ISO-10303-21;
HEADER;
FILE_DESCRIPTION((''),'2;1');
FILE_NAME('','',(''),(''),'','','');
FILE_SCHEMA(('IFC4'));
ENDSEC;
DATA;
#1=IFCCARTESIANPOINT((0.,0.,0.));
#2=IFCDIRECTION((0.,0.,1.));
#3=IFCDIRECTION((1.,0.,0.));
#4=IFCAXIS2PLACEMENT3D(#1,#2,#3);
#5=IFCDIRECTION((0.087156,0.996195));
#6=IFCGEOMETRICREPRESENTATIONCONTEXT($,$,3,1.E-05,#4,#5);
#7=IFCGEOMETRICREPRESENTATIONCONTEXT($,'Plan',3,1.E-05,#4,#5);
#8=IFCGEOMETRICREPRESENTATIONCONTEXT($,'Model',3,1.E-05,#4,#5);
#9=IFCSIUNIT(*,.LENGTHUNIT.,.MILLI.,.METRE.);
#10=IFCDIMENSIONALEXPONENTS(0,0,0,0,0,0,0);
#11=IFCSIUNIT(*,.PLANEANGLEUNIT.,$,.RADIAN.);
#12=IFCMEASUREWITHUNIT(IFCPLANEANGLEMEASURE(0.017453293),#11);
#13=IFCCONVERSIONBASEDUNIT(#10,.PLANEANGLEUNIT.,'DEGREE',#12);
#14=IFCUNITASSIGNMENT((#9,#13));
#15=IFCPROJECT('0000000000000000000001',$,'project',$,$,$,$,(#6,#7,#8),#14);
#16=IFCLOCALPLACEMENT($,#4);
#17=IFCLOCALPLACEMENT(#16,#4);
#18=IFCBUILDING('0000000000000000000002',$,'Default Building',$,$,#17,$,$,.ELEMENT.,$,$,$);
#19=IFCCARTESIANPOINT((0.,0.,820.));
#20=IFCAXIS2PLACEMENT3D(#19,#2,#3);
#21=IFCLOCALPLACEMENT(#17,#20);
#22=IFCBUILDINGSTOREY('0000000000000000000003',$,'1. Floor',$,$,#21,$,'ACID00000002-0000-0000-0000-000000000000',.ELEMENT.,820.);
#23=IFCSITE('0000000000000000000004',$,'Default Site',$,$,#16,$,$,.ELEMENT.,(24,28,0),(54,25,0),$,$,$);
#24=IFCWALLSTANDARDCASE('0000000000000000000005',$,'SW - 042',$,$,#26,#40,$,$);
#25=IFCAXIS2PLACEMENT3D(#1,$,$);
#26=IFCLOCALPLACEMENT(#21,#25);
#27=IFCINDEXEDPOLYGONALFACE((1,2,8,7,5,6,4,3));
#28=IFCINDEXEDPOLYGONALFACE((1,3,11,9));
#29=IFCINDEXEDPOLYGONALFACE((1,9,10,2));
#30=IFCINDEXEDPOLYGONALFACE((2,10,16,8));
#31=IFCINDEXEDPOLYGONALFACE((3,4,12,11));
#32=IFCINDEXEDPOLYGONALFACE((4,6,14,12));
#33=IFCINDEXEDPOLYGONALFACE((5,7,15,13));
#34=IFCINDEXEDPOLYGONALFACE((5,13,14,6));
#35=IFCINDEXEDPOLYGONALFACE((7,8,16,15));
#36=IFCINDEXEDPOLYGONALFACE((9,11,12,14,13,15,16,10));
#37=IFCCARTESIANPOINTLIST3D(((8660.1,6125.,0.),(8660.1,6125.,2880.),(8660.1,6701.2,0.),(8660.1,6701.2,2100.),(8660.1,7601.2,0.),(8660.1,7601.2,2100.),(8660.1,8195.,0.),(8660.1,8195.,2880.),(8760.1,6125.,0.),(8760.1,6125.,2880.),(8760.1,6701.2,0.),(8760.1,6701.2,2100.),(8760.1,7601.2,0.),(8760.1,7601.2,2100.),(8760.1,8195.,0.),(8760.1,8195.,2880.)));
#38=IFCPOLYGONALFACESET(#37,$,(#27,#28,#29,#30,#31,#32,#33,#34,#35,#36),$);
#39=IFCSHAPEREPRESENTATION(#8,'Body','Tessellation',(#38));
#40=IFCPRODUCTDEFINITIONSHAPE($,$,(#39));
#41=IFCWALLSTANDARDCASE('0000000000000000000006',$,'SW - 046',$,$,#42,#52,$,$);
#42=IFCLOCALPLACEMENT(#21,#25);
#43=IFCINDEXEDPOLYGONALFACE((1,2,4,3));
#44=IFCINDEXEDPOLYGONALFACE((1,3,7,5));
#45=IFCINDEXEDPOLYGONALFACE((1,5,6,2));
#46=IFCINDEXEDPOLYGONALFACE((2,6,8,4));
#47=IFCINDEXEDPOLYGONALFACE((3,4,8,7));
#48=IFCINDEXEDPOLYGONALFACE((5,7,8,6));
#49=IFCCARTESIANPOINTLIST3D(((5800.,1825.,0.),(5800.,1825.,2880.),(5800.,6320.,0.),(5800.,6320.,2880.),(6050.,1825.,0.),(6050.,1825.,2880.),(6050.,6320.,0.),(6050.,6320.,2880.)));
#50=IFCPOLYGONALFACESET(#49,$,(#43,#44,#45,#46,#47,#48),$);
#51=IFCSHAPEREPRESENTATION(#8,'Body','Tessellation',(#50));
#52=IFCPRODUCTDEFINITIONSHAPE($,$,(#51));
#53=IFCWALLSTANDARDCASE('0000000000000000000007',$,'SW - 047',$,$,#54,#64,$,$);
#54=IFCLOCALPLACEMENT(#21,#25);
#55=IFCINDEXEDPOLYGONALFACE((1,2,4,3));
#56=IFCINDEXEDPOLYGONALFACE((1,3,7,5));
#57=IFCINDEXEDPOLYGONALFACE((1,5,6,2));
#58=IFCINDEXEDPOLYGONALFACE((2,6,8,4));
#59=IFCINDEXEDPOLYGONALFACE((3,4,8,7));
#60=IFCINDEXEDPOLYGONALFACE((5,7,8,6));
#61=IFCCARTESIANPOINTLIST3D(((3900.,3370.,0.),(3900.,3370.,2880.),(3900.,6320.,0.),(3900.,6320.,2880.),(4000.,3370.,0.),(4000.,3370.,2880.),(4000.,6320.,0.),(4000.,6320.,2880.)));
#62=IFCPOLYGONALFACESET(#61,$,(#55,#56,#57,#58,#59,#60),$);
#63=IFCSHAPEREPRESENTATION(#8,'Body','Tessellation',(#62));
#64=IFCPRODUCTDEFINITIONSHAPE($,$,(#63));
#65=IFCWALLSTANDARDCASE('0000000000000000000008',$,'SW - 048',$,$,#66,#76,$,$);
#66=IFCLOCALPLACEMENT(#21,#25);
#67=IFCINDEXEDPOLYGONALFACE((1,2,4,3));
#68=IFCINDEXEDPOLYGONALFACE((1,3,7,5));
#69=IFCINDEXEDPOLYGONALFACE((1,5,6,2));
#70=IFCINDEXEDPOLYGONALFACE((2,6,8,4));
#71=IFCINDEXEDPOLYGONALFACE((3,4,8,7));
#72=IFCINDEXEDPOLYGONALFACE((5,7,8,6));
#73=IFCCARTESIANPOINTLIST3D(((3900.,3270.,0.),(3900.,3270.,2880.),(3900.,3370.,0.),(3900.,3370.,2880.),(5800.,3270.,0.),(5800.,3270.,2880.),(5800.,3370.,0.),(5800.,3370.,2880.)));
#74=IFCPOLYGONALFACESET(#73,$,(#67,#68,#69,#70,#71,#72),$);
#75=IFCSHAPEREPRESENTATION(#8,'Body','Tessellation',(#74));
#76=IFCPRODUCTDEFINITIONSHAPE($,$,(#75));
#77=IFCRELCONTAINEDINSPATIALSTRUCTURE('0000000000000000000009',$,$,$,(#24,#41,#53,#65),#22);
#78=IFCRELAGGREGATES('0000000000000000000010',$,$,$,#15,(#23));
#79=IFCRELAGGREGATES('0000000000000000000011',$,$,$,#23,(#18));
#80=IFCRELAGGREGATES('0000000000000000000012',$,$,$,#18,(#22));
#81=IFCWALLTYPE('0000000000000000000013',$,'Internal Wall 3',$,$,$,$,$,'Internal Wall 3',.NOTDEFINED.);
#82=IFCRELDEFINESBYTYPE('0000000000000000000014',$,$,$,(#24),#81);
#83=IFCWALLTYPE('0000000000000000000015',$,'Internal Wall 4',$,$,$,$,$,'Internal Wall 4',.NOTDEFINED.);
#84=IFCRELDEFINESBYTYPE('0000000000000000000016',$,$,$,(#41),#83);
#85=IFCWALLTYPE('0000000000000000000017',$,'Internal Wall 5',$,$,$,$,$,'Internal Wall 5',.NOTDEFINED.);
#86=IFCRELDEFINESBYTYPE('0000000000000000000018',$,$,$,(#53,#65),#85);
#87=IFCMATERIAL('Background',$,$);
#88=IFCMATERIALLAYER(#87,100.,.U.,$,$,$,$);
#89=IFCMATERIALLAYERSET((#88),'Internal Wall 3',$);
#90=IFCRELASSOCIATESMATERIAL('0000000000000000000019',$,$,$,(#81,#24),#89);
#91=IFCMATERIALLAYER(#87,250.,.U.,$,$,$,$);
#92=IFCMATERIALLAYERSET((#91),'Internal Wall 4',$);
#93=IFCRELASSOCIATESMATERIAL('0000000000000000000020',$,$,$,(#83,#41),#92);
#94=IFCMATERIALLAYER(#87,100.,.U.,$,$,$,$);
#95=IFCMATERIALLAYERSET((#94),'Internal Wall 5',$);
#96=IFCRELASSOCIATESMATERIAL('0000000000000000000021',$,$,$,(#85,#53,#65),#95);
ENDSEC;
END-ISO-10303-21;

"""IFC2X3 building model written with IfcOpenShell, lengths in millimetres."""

from ifc_helpers import new_model, entity, si_unit, converted_unit, direction, frame, frame_2d, origin_with_axes, place, context, project, spatial, polyline, rectangle, outline, extrude, material, layer, layer_set, layer_usage, type_object, element, save


model = new_model("IFC2X3")

# Units and contexts
context_of_model = context(None, 3, precision=1e-05, world=origin_with_axes(), true_north=direction((0.087156, 0.996195)))
plan_context = context("Plan", 3, precision=1e-05, world=origin_with_axes(), true_north=direction((0.087156, 0.996195)))
model_context = context("Model", 3, precision=1e-05, world=origin_with_axes(), true_north=direction((0.087156, 0.996195)))
ifc_project = project(units=[si_unit("LENGTHUNIT", "METRE", prefix="MILLI"), converted_unit("PLANEANGLEUNIT", "DEGREE", entity("IfcPlaneAngleMeasure", 0.017453293), si_unit("PLANEANGLEUNIT", "RADIAN"), dimensions=[0, 0, 0, 0, 0, 0, 0])], contexts=[context_of_model, plan_context, model_context])

# Site, building, storey
site_placement = place(None, origin_with_axes())
site = spatial("IfcSite", under=ifc_project, at=site_placement, Name="Default Site", CompositionType="ELEMENT", RefLatitude=(24, 28, 0), RefLongitude=(54, 25, 0))
building_placement = place(site_placement, origin_with_axes())
building = spatial("IfcBuilding", under=site, at=building_placement, Name="Default Building", CompositionType="ELEMENT")
storey_placement = place(building_placement, frame((0.0, 0.0, 820.0), z_axis=(0.0, 0.0, 1.0), x_axis=(1.0, 0.0, 0.0)))
storey = spatial("IfcBuildingStorey", under=building, at=storey_placement, Name="1. Floor", LongName="ACID00000002-0000-0000-0000-000000000000", CompositionType="ELEMENT", Elevation=820.0)

# Shared definitions
ifc_material_1 = material(Name="Background")

# Shared definitions
ifc_layer_1 = layer(ifc_material_1, 100.0, ventilated="UNKNOWN")
ifc_layer_set_1 = layer_set([ifc_layer_1], Name="Internal Wall 3")
wall_type_1 = type_object("IfcWallType", Name="Internal Wall 3", ElementType="Internal Wall 3", PredefinedType="NOTDEFINED", material=ifc_layer_set_1)

# Wall, opening
ifc_layer_usage_1 = layer_usage(ifc_layer_set_1, "AXIS2", "NEGATIVE", 0.0)
wall_1_placement = place(storey_placement, frame((8760.1, 8195.0, 0.0), z_axis=(0.0, 0.0, 1.0), x_axis=(0.0, -1.0, 0.0)))
wall_1 = element("IfcWallStandardCase", 1, at=wall_1_placement, inside=storey, type_object=wall_type_1, material=ifc_layer_usage_1, Name="SW - 042", context=model_context, shape_type="SweptSolid", body=[
    extrude(outline(polyline([(0.0, -100.0), (2070.0, -100.0), (2070.0, 0.0), (0.0, 0.0), (0.0, -100.0)])), origin_with_axes(), (0.0, 0.0, 1.0), 2880.0),
])
opening_1_placement = place(wall_1_placement, frame((1043.8, -100.0, 0.0), z_axis=(0.0, 0.0, 1.0), x_axis=(1.0, 0.0, 0.0)))
element("IfcOpeningElement", 2, at=opening_1_placement, cuts=wall_1, ObjectType="Opening", context=model_context, shape_type="SweptSolid", body=[
    extrude(rectangle(XDim=900.0, YDim=2100.0, at=frame_2d((0.0, 1050.0), x_axis=(-1.0, 0.0))), frame((0.0, 0.0, 0.0), z_axis=(0.0, 1.0, 0.0), x_axis=(-1.0, 0.0, 0.0)), (0.0, 0.0, 1.0), 100.0),
])

# Walls
ifc_layer_2 = layer(ifc_material_1, 250.0, ventilated="UNKNOWN")
ifc_layer_set_2 = layer_set([ifc_layer_2], Name="Internal Wall 4")
ifc_layer_usage_2 = layer_usage(ifc_layer_set_2, "AXIS2", "NEGATIVE", 0.0)
wall_type_2 = type_object("IfcWallType", Name="Internal Wall 4", ElementType="Internal Wall 4", PredefinedType="NOTDEFINED", material=ifc_layer_set_2)
wall_2_placement = place(storey_placement, frame((6050.0, 6320.0, 0.0), z_axis=(0.0, 0.0, 1.0), x_axis=(0.0, -1.0, 0.0)))
element("IfcWallStandardCase", 3, at=wall_2_placement, inside=storey, type_object=wall_type_2, material=ifc_layer_usage_2, Name="SW - 046", context=model_context, shape_type="SweptSolid", body=[
    extrude(outline(polyline([(0.0, -250.0), (4495.0, -250.0), (4495.0, 0.0), (0.0, 0.0), (0.0, -250.0)])), origin_with_axes(), (0.0, 0.0, 1.0), 2880.0),
])
ifc_layer_3 = layer(ifc_material_1, 100.0, ventilated="UNKNOWN")
ifc_layer_set_3 = layer_set([ifc_layer_3], Name="Internal Wall 5")
ifc_layer_usage_3 = layer_usage(ifc_layer_set_3, "AXIS2", "NEGATIVE", 0.0)
wall_type_3 = type_object("IfcWallType", Name="Internal Wall 5", ElementType="Internal Wall 5", PredefinedType="NOTDEFINED", material=ifc_layer_set_3)
wall_3_placement = place(storey_placement, frame((4000.0, 6320.0, 0.0), z_axis=(0.0, 0.0, 1.0), x_axis=(0.0, -1.0, 0.0)))
element("IfcWallStandardCase", 4, at=wall_3_placement, inside=storey, type_object=wall_type_3, material=ifc_layer_usage_3, Name="SW - 047", context=model_context, shape_type="SweptSolid", body=[
    extrude(outline(polyline([(0.0, -100.0), (2950.0, -100.0), (2950.0, 0.0), (0.0, 0.0), (0.0, -100.0)])), origin_with_axes(), (0.0, 0.0, 1.0), 2880.0),
])
ifc_layer_usage_4 = layer_usage(ifc_layer_set_3, "AXIS2", "POSITIVE", 0.0)
wall_4_placement = place(storey_placement, frame((3900.0, 3270.0, 0.0), z_axis=(0.0, 0.0, 1.0), x_axis=(1.0, 0.0, 0.0)))
element("IfcWallStandardCase", 5, at=wall_4_placement, inside=storey, type_object=wall_type_3, material=ifc_layer_usage_4, Name="SW - 048", context=model_context, shape_type="SweptSolid", body=[
    extrude(outline(polyline([(0.0, 0.0), (1900.0, 0.0), (1900.0, 100.0), (0.0, 100.0), (0.0, 0.0)])), origin_with_axes(), (0.0, 0.0, 1.0), 2880.0),
])

save(model, "model.ifc")
